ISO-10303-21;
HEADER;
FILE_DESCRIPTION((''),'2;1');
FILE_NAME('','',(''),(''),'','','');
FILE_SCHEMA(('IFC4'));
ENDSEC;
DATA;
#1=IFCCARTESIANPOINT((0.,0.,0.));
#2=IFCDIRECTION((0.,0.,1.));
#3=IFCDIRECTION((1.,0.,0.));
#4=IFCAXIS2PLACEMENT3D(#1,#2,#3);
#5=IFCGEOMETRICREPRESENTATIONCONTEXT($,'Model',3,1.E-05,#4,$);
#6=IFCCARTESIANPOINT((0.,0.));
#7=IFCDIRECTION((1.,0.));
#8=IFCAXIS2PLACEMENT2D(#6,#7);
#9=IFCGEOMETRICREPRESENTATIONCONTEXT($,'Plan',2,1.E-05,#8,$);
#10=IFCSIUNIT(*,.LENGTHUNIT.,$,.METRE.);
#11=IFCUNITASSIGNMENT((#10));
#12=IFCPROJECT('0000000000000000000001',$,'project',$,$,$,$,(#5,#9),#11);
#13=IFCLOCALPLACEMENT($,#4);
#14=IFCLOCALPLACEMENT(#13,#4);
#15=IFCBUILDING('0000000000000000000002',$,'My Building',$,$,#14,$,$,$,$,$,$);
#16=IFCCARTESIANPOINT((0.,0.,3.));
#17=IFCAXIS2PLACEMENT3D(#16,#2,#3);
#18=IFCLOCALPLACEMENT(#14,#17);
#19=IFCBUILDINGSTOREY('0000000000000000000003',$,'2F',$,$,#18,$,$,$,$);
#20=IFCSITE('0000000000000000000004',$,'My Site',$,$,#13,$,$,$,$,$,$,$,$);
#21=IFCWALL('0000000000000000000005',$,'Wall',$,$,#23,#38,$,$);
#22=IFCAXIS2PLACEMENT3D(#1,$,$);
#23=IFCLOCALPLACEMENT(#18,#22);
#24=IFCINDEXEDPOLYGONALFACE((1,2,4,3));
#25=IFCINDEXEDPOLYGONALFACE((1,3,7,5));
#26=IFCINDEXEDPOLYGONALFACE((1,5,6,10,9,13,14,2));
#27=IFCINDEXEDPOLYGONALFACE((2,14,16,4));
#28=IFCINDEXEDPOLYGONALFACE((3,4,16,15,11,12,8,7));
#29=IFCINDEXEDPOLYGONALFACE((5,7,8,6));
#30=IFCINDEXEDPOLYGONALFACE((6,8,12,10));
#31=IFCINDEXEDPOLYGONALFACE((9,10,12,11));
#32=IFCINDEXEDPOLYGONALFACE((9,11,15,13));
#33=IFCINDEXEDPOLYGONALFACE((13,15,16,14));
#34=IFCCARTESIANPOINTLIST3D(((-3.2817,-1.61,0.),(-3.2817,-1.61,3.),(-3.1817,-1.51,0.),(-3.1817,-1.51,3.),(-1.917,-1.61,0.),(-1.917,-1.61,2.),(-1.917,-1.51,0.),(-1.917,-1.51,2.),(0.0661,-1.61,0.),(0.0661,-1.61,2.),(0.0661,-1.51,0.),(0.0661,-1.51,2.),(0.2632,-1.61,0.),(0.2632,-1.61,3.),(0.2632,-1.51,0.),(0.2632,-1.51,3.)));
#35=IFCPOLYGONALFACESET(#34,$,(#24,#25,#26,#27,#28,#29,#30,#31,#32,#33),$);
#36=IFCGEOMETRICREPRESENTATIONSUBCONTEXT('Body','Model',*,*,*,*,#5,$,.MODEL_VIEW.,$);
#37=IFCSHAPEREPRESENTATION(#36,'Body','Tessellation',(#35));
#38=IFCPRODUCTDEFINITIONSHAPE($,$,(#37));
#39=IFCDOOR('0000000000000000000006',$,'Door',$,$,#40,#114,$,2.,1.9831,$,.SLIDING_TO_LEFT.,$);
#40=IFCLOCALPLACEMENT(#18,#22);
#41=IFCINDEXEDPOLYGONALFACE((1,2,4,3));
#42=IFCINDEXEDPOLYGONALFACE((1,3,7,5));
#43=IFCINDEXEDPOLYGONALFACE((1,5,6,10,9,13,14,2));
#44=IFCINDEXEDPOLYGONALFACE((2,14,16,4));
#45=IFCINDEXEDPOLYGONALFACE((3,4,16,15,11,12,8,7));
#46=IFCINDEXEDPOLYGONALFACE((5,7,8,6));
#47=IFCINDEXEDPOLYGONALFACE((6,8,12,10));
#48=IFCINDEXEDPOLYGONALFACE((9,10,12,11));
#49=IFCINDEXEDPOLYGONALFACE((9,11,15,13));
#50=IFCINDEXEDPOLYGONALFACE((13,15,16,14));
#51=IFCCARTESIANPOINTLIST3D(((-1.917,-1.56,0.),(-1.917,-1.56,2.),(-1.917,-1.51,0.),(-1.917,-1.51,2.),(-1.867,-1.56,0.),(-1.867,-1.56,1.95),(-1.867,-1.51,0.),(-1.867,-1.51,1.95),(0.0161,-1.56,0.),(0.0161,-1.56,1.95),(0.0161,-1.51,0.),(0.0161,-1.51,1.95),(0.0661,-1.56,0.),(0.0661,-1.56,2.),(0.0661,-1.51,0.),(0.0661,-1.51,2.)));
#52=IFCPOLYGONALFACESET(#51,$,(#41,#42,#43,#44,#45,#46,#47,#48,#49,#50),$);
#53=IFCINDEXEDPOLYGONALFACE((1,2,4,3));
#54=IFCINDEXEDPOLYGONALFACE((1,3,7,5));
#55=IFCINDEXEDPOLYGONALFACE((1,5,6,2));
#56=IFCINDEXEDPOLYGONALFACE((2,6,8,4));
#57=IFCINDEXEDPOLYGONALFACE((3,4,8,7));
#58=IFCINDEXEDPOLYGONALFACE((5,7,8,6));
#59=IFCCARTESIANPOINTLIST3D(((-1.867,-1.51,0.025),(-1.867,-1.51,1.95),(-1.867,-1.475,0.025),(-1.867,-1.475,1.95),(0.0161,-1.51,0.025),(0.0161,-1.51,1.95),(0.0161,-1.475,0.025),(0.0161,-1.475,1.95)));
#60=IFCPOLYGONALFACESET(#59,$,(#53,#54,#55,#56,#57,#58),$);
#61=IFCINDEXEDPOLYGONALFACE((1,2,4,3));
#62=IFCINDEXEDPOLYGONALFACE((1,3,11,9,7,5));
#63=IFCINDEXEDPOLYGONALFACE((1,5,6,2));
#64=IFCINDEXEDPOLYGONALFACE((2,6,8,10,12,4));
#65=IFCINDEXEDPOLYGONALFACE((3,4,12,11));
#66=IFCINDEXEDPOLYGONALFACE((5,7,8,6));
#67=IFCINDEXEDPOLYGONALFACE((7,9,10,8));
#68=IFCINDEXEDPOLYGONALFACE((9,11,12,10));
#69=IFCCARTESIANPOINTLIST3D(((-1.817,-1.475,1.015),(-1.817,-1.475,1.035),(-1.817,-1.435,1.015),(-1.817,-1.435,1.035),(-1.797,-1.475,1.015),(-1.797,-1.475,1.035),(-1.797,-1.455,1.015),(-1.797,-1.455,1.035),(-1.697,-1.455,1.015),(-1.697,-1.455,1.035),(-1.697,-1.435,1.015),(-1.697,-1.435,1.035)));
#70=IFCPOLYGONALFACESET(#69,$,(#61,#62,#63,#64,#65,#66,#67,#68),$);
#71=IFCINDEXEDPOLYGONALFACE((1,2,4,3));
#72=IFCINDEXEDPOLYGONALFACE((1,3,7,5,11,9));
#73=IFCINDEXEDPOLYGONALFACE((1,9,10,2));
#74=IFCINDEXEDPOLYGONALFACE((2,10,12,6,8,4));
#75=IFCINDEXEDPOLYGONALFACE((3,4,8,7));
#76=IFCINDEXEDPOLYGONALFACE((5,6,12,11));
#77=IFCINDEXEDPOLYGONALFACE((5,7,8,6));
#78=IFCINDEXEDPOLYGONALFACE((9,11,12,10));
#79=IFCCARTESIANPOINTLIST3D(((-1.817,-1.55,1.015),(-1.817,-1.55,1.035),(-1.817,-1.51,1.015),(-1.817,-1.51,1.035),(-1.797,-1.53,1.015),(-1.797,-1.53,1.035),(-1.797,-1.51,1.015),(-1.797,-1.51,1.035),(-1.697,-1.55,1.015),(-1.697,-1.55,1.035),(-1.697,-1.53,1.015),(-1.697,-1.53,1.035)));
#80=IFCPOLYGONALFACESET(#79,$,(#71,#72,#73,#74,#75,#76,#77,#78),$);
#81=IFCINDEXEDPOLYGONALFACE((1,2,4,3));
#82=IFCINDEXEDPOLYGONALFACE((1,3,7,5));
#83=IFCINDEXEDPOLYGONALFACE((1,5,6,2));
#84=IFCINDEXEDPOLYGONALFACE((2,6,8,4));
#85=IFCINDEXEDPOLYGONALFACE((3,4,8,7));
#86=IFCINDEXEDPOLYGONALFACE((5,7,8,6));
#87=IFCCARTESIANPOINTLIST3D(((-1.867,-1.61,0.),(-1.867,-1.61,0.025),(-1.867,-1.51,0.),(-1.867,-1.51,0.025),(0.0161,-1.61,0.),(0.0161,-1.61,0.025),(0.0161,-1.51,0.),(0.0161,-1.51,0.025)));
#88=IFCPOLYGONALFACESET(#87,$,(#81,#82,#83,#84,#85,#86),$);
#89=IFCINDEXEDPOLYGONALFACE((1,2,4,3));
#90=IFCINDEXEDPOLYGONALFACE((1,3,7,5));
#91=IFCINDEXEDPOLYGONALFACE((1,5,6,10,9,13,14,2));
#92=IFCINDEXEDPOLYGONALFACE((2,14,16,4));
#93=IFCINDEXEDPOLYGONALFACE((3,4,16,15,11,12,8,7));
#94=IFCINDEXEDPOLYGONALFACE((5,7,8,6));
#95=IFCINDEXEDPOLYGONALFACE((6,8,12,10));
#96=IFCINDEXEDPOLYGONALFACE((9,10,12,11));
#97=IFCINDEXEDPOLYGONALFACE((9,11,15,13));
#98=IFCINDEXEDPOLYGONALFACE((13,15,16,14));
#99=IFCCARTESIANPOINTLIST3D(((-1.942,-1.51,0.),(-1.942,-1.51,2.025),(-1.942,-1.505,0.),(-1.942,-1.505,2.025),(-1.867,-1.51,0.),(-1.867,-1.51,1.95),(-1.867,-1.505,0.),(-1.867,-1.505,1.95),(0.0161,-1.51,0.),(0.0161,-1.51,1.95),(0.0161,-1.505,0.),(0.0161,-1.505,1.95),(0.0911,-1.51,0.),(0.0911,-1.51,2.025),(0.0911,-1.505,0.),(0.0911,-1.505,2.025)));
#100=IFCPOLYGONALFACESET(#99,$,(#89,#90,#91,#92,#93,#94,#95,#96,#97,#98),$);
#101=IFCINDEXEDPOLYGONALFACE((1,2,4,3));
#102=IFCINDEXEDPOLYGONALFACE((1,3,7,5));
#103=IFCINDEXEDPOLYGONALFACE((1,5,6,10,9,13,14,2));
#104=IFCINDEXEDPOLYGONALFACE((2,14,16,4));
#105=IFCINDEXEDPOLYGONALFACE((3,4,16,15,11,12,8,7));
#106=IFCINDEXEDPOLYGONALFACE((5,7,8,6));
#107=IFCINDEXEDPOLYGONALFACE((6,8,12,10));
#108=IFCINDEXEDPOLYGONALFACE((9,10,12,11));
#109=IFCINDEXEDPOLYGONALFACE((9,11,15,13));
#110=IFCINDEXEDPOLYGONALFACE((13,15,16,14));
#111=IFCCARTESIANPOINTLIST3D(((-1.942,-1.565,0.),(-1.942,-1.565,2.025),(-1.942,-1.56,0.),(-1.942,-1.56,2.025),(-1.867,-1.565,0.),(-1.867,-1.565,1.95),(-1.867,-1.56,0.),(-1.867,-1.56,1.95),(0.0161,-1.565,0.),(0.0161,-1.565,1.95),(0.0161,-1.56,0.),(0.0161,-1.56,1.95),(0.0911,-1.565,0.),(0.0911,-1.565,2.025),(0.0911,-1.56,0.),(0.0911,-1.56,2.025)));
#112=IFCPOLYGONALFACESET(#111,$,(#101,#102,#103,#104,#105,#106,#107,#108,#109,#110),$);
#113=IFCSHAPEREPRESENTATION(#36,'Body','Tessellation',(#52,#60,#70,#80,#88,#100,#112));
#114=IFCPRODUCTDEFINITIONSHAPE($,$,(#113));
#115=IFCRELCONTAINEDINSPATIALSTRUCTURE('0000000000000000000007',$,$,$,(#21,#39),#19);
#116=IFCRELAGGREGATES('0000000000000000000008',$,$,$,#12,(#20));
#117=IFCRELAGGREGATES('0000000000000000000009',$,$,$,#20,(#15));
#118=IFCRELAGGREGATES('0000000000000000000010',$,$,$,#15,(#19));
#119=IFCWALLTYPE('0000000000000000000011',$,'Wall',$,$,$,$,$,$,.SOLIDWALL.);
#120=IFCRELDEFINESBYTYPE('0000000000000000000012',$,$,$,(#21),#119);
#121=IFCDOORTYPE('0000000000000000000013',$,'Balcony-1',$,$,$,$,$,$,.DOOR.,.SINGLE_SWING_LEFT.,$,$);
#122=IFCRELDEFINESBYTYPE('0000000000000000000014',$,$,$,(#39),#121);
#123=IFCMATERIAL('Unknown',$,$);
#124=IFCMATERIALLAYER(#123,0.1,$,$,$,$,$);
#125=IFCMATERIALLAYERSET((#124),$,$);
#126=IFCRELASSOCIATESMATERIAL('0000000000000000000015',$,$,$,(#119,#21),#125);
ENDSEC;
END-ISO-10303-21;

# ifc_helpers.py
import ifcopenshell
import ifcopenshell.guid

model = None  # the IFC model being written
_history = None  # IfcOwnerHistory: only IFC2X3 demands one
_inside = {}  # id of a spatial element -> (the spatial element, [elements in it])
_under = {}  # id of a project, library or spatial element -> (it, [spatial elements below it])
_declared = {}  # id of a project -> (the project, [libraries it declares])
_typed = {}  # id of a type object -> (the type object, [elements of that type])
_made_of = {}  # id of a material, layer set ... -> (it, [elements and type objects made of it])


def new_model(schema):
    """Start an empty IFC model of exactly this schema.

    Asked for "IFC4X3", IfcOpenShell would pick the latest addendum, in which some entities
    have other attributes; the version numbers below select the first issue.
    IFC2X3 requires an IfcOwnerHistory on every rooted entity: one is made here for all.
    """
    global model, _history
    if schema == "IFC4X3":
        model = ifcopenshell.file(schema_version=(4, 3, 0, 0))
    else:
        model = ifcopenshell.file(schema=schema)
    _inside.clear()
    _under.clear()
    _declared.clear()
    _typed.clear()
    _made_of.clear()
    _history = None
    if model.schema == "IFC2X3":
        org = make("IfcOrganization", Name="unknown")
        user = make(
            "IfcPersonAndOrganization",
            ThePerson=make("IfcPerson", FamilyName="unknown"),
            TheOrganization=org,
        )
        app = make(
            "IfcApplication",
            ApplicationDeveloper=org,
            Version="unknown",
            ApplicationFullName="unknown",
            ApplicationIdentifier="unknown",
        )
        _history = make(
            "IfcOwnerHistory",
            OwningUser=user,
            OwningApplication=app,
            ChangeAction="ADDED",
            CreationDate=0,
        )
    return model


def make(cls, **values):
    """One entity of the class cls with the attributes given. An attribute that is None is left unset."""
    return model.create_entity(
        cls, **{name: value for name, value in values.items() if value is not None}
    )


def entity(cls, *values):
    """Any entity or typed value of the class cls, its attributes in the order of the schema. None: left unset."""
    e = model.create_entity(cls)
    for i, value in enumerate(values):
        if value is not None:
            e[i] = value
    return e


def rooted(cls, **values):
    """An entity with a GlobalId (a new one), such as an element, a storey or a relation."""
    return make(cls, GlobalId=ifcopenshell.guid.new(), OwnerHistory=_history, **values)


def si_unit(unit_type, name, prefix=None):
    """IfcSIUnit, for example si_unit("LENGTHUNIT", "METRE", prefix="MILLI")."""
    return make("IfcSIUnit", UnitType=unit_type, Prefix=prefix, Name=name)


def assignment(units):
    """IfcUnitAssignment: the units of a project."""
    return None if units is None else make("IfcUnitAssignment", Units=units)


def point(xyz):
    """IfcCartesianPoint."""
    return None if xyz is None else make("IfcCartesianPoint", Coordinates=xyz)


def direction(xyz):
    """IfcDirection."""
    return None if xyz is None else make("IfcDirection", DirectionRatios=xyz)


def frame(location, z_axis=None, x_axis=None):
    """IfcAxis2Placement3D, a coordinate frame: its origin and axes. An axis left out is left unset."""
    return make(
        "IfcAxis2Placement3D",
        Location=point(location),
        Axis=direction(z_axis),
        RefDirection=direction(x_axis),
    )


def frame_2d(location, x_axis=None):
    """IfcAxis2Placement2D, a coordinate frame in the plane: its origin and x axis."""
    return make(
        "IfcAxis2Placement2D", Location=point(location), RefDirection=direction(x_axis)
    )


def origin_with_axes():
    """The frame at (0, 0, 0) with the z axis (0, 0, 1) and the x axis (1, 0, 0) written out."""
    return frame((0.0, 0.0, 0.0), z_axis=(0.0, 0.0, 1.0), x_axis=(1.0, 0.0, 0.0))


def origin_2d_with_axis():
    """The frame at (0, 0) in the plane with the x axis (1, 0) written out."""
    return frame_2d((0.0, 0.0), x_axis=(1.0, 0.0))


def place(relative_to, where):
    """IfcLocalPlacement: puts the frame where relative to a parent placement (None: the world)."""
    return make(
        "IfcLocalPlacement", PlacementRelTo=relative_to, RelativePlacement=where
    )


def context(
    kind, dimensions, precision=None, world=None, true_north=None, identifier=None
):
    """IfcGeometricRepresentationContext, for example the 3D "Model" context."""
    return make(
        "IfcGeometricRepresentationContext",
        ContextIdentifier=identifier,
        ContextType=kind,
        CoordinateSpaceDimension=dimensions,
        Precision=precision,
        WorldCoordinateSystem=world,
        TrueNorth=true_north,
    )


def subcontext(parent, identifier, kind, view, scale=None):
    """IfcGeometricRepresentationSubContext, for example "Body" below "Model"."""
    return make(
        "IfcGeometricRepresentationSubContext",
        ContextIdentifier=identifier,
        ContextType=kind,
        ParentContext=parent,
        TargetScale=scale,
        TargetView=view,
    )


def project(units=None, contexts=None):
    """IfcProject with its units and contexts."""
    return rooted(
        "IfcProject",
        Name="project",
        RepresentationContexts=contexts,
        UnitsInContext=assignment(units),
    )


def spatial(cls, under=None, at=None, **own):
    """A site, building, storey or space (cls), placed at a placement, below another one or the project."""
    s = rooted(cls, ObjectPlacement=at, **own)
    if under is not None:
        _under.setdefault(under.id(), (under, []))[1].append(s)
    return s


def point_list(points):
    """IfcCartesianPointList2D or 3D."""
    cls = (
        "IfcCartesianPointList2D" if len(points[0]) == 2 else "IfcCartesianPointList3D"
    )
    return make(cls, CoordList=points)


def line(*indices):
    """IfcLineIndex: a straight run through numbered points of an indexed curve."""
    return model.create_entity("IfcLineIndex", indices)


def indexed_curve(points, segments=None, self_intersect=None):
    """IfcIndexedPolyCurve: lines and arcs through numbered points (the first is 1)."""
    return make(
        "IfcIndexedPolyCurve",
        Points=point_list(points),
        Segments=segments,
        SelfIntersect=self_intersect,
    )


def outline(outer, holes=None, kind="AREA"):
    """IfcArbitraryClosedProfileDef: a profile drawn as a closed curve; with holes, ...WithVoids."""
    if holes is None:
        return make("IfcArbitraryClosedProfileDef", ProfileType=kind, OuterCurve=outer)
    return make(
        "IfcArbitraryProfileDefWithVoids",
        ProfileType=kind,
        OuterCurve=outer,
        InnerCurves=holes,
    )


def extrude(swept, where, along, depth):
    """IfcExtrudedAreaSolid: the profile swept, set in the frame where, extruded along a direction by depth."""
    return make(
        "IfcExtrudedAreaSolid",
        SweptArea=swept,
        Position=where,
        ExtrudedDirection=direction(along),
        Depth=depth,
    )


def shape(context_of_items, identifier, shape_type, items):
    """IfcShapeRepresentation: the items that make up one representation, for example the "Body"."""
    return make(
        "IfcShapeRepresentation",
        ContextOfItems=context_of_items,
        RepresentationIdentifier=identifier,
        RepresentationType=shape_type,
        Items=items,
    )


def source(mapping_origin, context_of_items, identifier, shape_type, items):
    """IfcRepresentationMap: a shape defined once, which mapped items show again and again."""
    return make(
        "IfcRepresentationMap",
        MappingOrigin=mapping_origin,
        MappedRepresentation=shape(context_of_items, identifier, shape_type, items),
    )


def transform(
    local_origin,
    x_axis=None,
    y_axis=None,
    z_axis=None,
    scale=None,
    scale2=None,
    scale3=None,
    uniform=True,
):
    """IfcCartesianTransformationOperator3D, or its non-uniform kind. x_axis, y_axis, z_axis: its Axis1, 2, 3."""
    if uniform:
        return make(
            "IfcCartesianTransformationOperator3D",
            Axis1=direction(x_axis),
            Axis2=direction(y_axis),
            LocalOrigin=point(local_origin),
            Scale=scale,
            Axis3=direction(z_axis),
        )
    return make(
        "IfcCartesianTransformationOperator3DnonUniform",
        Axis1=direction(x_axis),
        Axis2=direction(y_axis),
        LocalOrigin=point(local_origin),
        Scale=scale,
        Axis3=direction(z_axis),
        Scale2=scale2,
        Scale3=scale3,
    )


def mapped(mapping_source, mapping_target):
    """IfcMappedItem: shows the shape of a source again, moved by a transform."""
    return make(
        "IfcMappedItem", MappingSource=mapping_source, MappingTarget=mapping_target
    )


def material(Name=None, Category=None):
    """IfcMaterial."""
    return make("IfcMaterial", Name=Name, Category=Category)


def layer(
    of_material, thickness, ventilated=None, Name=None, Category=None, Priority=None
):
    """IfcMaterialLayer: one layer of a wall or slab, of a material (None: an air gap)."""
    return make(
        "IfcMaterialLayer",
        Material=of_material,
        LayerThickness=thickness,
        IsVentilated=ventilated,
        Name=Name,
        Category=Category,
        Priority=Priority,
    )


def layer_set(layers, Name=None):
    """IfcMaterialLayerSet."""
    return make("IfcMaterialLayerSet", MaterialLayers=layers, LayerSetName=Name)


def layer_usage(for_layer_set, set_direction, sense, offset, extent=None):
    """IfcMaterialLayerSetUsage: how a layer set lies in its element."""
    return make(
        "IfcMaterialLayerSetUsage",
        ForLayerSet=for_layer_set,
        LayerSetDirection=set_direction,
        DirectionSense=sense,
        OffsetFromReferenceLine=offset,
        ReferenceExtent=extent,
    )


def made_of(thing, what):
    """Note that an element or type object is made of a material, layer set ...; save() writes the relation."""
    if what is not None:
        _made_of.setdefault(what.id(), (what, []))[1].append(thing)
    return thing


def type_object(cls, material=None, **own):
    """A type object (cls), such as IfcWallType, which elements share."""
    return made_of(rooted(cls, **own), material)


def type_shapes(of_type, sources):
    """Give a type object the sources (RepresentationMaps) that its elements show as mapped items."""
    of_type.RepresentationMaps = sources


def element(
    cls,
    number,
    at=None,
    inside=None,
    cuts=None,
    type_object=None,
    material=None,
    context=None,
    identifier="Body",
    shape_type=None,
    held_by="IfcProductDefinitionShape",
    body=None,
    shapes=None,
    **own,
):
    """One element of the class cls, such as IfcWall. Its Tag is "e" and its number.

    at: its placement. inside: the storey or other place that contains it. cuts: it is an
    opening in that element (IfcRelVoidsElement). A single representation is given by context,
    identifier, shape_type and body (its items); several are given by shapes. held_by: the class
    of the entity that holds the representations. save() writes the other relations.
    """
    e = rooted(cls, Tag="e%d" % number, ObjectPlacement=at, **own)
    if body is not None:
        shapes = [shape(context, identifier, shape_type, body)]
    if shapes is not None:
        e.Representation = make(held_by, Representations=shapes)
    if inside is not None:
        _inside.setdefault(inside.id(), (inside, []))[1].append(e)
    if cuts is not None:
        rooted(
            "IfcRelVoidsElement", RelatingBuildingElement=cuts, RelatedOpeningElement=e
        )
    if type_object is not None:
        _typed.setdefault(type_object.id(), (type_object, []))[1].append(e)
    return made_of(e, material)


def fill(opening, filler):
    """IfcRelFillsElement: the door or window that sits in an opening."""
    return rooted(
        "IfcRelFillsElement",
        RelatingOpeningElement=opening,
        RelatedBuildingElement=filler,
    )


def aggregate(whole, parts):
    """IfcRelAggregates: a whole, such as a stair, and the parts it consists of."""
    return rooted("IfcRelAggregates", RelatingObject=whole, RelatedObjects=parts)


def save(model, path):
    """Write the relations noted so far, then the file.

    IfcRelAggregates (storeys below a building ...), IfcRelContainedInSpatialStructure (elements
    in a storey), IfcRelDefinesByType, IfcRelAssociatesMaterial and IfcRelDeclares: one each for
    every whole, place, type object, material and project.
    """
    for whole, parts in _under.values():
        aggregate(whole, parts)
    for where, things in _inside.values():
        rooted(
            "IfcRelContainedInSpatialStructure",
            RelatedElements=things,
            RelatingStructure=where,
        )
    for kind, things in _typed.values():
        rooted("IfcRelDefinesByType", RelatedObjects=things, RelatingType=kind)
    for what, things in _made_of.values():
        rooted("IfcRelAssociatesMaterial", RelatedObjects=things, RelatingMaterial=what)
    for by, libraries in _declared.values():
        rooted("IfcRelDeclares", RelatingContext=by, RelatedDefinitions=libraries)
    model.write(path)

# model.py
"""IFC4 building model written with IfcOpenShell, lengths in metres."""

from ifc_helpers import new_model, entity, si_unit, frame, origin_with_axes, origin_2d_with_axis, place, context, subcontext, project, spatial, line, indexed_curve, outline, extrude, shape, source, transform, mapped, material, layer, layer_set, layer_usage, type_object, type_shapes, element, fill, save


model = new_model("IFC4")

# Units and contexts
model_context_1 = context("Model", 3, precision=1e-05, world=origin_with_axes())
plan_context = context("Plan", 2, precision=1e-05, world=origin_2d_with_axis())
body_context_1 = subcontext(model_context_1, "Body", "Model", "MODEL_VIEW")
body_context_2 = subcontext(plan_context, "Body", "Plan", "PLAN_VIEW")
ifc_project = project(units=[si_unit("LENGTHUNIT", "METRE")], contexts=[model_context_1, plan_context])

# Site, building, storey
site_placement = place(None, origin_with_axes())
site = spatial("IfcSite", under=ifc_project, at=site_placement, Name="My Site")
building_placement = place(site_placement, origin_with_axes())
building = spatial("IfcBuilding", under=site, at=building_placement, Name="My Building")
storey_placement = place(building_placement, frame((0.0, 0.0, 3.0), z_axis=(0.0, 0.0, 1.0), x_axis=(1.0, 0.0, 0.0)))
storey = spatial("IfcBuildingStorey", under=building, at=storey_placement, Name="2F")

# Wall, opening, door
ifc_material_1 = material(Name="Unknown")
ifc_layer = layer(ifc_material_1, 0.1)
ifc_layer_set = layer_set([ifc_layer])
ifc_layer_usage_1 = layer_usage(ifc_layer_set, "AXIS2", "POSITIVE", 0.0)
wall_type = type_object("IfcWallType", Name="Wall", PredefinedType="SOLIDWALL", material=ifc_layer_set)
wall_1_placement = place(storey_placement, frame((-3.2817, -1.61, 0.0), z_axis=(0.0, 0.0, 1.0), x_axis=(1.0, 0.0, 0.0)))
wall_1 = element("IfcWall", 1, at=wall_1_placement, inside=storey, type_object=wall_type, material=ifc_layer_usage_1, Name="Wall", context=body_context_1, shape_type="SweptSolid", body=[
    extrude(outline(indexed_curve([(0.0, 0.0), (0.1, 0.1), (3.5448, 0.1), (3.5448, 0.0)], segments=[line(1, 2, 3, 4, 1)])), origin_with_axes(), (0.0, 0.0, 1.0), 3.0),
])
shared_shape_1 = source(origin_with_axes(), body_context_1, "Body", "SweptSolid", [
    extrude(outline(indexed_curve([(0.0, 0.0), (1.9831, 0.0), (1.9831, 2.0), (0.0, 2.0)], segments=[line(1, 2, 3, 4, 1)])), frame((0.0, -0.6, 0.0), z_axis=(0.0, -1.0, 0.0), x_axis=(1.0, 0.0, 0.0)), (0.0, 0.0, -1.0), 1.2),
])
opening_1_placement = place(wall_1_placement, frame((3.3477, 0.1, 0.0), z_axis=(0.0, 0.0, 1.0), x_axis=(-1.0, 0.0, 0.0)))
opening_1 = element("IfcOpeningElement", 2, at=opening_1_placement, cuts=wall_1, PredefinedType="OPENING", context=body_context_1, shape_type="MappedRepresentation", body=[
    mapped(shared_shape_1, transform((0.0, 0.0, 0.0), x_axis=(1.0, 0.0, 0.0), y_axis=(0.0, 1.0, 0.0), z_axis=(0.0, 0.0, 1.0), scale=1.0)),
])
door_type_1 = type_object("IfcDoorType", Name="Balcony-1", OperationType="SINGLE_SWING_LEFT", PredefinedType="DOOR")
shared_shape_2 = source(origin_with_axes(), body_context_1, "Body", "SweptSolid", [
    extrude(outline(indexed_curve([(0.0, 0.0), (0.0, 2.0), (1.9831, 2.0), (1.9831, 0.0), (1.9331, 0.0), (1.9331, 1.95), (0.05, 1.95), (0.05, 0.0)], segments=[line(1, 2, 3, 4, 5, 6, 7, 8, 1)])), frame((0.0, 0.0, 0.0), z_axis=(0.0, -1.0, 0.0), x_axis=(1.0, 0.0, 0.0)), (0.0, 0.0, -1.0), 0.05),
    extrude(outline(indexed_curve([(0.0, 0.0), (1.8831, 0.0), (1.8831, 0.035), (0.0, 0.035)], segments=[line(1, 2, 3, 4, 1)])), frame((0.05, -0.035, 0.025), z_axis=(0.0, 0.0, 1.0), x_axis=(1.0, 0.0, 0.0)), (0.0, 0.0, 1.0), 1.925),
    extrude(outline(indexed_curve([(0.0, 0.0), (0.0, -0.04), (-0.12, -0.04), (-0.12, -0.02), (-0.02, -0.02), (-0.02, 0.0)], segments=[line(1, 2, 3, 4, 5, 6, 1)])), frame((1.8831, -0.035, 1.015), z_axis=(0.0, 0.0, 1.0), x_axis=(1.0, 0.0, 0.0)), (0.0, 0.0, 1.0), 0.02),
    extrude(outline(indexed_curve([(0.0, 0.0), (0.0, 0.04), (-0.12, 0.04), (-0.12, 0.02), (-0.02, 0.02), (-0.02, 0.0)], segments=[line(1, 2, 3, 4, 5, 6, 1)])), frame((1.8831, 0.0, 1.015), z_axis=(0.0, 0.0, 1.0), x_axis=(1.0, 0.0, 0.0)), (0.0, 0.0, 1.0), 0.02),
    extrude(outline(indexed_curve([(0.0, 0.0), (1.8831, 0.0), (1.8831, 0.1), (0.0, 0.1)], segments=[line(1, 2, 3, 4, 1)])), frame((0.05, 0.0, 0.0), z_axis=(0.0, 0.0, 1.0), x_axis=(1.0, 0.0, 0.0)), (0.0, 0.0, 1.0), 0.025),
    extrude(outline(indexed_curve([(0.0, 0.0), (0.0, 2.025), (2.0331, 2.025), (2.0331, 0.0), (1.9581, 0.0), (1.9581, 1.95), (0.075, 1.95), (0.075, 0.0)], segments=[line(1, 2, 3, 4, 5, 6, 7, 8, 1)])), frame((-0.025, -0.005, 0.0), z_axis=(0.0, -1.0, 0.0), x_axis=(1.0, 0.0, 0.0)), (0.0, 0.0, -1.0), 0.005),
    extrude(outline(indexed_curve([(0.0, 0.0), (0.0, 2.025), (2.0331, 2.025), (2.0331, 0.0), (1.9581, 0.0), (1.9581, 1.95), (0.075, 1.95), (0.075, 0.0)], segments=[line(1, 2, 3, 4, 5, 6, 7, 8, 1)])), frame((-0.025, 0.05, 0.0), z_axis=(0.0, -1.0, 0.0), x_axis=(1.0, 0.0, 0.0)), (0.0, 0.0, -1.0), 0.005),
])
shared_shape_3 = source(origin_with_axes(), body_context_2, "Body", "Curve2D", [
    entity("IfcIndexedPolyCurve", entity("IfcCartesianPointList2D", [[0.0, 0.0], [0.05, 0.0], [0.05, 0.05], [0.0, 0.05]]), [entity("IfcLineIndex", [1, 2, 3, 4, 1])]),
    entity("IfcIndexedPolyCurve", entity("IfcCartesianPointList2D", [[1.9831, 0.0], [1.9331, 0.0], [1.9331, 0.05], [1.9831, 0.05]]), [entity("IfcLineIndex", [1, 2, 3, 4, 1])]),
    entity("IfcIndexedPolyCurve", entity("IfcCartesianPointList2D", [[-0.8915, -0.035], [0.9915, -0.035], [0.9915, 0.0], [-0.8915, 0.0]]), [entity("IfcLineIndex", [1, 2, 3, 4, 1])]),
])
type_shapes(door_type_1, [shared_shape_2, shared_shape_3])
door_1_placement = place(opening_1_placement, frame((0.0, 0.0, 0.0), z_axis=(0.0, 0.0, 1.0), x_axis=(1.0, 0.0, 0.0)))
door_1 = element("IfcDoor", 3, at=door_1_placement, inside=storey, type_object=door_type_1, Name="Door", OperationType="SLIDING_TO_LEFT", OverallHeight=2.0, OverallWidth=1.9831, shapes=[
    shape(body_context_1, "Body", "MappedRepresentation", [mapped(shared_shape_2, transform((0.0, 0.0, 0.0), x_axis=(1.0, 0.0, 0.0), y_axis=(0.0, 1.0, 0.0), z_axis=(0.0, 0.0, 1.0), scale=1.0))]),
    shape(body_context_2, "Body", "MappedRepresentation", [mapped(shared_shape_3, transform((0.0, 0.0, 0.0), x_axis=(1.0, 0.0, 0.0), y_axis=(0.0, 1.0, 0.0), z_axis=(0.0, 0.0, 1.0), scale=1.0))]),
])
fill(opening_1, door_1)

save(model, "model.ifc")
